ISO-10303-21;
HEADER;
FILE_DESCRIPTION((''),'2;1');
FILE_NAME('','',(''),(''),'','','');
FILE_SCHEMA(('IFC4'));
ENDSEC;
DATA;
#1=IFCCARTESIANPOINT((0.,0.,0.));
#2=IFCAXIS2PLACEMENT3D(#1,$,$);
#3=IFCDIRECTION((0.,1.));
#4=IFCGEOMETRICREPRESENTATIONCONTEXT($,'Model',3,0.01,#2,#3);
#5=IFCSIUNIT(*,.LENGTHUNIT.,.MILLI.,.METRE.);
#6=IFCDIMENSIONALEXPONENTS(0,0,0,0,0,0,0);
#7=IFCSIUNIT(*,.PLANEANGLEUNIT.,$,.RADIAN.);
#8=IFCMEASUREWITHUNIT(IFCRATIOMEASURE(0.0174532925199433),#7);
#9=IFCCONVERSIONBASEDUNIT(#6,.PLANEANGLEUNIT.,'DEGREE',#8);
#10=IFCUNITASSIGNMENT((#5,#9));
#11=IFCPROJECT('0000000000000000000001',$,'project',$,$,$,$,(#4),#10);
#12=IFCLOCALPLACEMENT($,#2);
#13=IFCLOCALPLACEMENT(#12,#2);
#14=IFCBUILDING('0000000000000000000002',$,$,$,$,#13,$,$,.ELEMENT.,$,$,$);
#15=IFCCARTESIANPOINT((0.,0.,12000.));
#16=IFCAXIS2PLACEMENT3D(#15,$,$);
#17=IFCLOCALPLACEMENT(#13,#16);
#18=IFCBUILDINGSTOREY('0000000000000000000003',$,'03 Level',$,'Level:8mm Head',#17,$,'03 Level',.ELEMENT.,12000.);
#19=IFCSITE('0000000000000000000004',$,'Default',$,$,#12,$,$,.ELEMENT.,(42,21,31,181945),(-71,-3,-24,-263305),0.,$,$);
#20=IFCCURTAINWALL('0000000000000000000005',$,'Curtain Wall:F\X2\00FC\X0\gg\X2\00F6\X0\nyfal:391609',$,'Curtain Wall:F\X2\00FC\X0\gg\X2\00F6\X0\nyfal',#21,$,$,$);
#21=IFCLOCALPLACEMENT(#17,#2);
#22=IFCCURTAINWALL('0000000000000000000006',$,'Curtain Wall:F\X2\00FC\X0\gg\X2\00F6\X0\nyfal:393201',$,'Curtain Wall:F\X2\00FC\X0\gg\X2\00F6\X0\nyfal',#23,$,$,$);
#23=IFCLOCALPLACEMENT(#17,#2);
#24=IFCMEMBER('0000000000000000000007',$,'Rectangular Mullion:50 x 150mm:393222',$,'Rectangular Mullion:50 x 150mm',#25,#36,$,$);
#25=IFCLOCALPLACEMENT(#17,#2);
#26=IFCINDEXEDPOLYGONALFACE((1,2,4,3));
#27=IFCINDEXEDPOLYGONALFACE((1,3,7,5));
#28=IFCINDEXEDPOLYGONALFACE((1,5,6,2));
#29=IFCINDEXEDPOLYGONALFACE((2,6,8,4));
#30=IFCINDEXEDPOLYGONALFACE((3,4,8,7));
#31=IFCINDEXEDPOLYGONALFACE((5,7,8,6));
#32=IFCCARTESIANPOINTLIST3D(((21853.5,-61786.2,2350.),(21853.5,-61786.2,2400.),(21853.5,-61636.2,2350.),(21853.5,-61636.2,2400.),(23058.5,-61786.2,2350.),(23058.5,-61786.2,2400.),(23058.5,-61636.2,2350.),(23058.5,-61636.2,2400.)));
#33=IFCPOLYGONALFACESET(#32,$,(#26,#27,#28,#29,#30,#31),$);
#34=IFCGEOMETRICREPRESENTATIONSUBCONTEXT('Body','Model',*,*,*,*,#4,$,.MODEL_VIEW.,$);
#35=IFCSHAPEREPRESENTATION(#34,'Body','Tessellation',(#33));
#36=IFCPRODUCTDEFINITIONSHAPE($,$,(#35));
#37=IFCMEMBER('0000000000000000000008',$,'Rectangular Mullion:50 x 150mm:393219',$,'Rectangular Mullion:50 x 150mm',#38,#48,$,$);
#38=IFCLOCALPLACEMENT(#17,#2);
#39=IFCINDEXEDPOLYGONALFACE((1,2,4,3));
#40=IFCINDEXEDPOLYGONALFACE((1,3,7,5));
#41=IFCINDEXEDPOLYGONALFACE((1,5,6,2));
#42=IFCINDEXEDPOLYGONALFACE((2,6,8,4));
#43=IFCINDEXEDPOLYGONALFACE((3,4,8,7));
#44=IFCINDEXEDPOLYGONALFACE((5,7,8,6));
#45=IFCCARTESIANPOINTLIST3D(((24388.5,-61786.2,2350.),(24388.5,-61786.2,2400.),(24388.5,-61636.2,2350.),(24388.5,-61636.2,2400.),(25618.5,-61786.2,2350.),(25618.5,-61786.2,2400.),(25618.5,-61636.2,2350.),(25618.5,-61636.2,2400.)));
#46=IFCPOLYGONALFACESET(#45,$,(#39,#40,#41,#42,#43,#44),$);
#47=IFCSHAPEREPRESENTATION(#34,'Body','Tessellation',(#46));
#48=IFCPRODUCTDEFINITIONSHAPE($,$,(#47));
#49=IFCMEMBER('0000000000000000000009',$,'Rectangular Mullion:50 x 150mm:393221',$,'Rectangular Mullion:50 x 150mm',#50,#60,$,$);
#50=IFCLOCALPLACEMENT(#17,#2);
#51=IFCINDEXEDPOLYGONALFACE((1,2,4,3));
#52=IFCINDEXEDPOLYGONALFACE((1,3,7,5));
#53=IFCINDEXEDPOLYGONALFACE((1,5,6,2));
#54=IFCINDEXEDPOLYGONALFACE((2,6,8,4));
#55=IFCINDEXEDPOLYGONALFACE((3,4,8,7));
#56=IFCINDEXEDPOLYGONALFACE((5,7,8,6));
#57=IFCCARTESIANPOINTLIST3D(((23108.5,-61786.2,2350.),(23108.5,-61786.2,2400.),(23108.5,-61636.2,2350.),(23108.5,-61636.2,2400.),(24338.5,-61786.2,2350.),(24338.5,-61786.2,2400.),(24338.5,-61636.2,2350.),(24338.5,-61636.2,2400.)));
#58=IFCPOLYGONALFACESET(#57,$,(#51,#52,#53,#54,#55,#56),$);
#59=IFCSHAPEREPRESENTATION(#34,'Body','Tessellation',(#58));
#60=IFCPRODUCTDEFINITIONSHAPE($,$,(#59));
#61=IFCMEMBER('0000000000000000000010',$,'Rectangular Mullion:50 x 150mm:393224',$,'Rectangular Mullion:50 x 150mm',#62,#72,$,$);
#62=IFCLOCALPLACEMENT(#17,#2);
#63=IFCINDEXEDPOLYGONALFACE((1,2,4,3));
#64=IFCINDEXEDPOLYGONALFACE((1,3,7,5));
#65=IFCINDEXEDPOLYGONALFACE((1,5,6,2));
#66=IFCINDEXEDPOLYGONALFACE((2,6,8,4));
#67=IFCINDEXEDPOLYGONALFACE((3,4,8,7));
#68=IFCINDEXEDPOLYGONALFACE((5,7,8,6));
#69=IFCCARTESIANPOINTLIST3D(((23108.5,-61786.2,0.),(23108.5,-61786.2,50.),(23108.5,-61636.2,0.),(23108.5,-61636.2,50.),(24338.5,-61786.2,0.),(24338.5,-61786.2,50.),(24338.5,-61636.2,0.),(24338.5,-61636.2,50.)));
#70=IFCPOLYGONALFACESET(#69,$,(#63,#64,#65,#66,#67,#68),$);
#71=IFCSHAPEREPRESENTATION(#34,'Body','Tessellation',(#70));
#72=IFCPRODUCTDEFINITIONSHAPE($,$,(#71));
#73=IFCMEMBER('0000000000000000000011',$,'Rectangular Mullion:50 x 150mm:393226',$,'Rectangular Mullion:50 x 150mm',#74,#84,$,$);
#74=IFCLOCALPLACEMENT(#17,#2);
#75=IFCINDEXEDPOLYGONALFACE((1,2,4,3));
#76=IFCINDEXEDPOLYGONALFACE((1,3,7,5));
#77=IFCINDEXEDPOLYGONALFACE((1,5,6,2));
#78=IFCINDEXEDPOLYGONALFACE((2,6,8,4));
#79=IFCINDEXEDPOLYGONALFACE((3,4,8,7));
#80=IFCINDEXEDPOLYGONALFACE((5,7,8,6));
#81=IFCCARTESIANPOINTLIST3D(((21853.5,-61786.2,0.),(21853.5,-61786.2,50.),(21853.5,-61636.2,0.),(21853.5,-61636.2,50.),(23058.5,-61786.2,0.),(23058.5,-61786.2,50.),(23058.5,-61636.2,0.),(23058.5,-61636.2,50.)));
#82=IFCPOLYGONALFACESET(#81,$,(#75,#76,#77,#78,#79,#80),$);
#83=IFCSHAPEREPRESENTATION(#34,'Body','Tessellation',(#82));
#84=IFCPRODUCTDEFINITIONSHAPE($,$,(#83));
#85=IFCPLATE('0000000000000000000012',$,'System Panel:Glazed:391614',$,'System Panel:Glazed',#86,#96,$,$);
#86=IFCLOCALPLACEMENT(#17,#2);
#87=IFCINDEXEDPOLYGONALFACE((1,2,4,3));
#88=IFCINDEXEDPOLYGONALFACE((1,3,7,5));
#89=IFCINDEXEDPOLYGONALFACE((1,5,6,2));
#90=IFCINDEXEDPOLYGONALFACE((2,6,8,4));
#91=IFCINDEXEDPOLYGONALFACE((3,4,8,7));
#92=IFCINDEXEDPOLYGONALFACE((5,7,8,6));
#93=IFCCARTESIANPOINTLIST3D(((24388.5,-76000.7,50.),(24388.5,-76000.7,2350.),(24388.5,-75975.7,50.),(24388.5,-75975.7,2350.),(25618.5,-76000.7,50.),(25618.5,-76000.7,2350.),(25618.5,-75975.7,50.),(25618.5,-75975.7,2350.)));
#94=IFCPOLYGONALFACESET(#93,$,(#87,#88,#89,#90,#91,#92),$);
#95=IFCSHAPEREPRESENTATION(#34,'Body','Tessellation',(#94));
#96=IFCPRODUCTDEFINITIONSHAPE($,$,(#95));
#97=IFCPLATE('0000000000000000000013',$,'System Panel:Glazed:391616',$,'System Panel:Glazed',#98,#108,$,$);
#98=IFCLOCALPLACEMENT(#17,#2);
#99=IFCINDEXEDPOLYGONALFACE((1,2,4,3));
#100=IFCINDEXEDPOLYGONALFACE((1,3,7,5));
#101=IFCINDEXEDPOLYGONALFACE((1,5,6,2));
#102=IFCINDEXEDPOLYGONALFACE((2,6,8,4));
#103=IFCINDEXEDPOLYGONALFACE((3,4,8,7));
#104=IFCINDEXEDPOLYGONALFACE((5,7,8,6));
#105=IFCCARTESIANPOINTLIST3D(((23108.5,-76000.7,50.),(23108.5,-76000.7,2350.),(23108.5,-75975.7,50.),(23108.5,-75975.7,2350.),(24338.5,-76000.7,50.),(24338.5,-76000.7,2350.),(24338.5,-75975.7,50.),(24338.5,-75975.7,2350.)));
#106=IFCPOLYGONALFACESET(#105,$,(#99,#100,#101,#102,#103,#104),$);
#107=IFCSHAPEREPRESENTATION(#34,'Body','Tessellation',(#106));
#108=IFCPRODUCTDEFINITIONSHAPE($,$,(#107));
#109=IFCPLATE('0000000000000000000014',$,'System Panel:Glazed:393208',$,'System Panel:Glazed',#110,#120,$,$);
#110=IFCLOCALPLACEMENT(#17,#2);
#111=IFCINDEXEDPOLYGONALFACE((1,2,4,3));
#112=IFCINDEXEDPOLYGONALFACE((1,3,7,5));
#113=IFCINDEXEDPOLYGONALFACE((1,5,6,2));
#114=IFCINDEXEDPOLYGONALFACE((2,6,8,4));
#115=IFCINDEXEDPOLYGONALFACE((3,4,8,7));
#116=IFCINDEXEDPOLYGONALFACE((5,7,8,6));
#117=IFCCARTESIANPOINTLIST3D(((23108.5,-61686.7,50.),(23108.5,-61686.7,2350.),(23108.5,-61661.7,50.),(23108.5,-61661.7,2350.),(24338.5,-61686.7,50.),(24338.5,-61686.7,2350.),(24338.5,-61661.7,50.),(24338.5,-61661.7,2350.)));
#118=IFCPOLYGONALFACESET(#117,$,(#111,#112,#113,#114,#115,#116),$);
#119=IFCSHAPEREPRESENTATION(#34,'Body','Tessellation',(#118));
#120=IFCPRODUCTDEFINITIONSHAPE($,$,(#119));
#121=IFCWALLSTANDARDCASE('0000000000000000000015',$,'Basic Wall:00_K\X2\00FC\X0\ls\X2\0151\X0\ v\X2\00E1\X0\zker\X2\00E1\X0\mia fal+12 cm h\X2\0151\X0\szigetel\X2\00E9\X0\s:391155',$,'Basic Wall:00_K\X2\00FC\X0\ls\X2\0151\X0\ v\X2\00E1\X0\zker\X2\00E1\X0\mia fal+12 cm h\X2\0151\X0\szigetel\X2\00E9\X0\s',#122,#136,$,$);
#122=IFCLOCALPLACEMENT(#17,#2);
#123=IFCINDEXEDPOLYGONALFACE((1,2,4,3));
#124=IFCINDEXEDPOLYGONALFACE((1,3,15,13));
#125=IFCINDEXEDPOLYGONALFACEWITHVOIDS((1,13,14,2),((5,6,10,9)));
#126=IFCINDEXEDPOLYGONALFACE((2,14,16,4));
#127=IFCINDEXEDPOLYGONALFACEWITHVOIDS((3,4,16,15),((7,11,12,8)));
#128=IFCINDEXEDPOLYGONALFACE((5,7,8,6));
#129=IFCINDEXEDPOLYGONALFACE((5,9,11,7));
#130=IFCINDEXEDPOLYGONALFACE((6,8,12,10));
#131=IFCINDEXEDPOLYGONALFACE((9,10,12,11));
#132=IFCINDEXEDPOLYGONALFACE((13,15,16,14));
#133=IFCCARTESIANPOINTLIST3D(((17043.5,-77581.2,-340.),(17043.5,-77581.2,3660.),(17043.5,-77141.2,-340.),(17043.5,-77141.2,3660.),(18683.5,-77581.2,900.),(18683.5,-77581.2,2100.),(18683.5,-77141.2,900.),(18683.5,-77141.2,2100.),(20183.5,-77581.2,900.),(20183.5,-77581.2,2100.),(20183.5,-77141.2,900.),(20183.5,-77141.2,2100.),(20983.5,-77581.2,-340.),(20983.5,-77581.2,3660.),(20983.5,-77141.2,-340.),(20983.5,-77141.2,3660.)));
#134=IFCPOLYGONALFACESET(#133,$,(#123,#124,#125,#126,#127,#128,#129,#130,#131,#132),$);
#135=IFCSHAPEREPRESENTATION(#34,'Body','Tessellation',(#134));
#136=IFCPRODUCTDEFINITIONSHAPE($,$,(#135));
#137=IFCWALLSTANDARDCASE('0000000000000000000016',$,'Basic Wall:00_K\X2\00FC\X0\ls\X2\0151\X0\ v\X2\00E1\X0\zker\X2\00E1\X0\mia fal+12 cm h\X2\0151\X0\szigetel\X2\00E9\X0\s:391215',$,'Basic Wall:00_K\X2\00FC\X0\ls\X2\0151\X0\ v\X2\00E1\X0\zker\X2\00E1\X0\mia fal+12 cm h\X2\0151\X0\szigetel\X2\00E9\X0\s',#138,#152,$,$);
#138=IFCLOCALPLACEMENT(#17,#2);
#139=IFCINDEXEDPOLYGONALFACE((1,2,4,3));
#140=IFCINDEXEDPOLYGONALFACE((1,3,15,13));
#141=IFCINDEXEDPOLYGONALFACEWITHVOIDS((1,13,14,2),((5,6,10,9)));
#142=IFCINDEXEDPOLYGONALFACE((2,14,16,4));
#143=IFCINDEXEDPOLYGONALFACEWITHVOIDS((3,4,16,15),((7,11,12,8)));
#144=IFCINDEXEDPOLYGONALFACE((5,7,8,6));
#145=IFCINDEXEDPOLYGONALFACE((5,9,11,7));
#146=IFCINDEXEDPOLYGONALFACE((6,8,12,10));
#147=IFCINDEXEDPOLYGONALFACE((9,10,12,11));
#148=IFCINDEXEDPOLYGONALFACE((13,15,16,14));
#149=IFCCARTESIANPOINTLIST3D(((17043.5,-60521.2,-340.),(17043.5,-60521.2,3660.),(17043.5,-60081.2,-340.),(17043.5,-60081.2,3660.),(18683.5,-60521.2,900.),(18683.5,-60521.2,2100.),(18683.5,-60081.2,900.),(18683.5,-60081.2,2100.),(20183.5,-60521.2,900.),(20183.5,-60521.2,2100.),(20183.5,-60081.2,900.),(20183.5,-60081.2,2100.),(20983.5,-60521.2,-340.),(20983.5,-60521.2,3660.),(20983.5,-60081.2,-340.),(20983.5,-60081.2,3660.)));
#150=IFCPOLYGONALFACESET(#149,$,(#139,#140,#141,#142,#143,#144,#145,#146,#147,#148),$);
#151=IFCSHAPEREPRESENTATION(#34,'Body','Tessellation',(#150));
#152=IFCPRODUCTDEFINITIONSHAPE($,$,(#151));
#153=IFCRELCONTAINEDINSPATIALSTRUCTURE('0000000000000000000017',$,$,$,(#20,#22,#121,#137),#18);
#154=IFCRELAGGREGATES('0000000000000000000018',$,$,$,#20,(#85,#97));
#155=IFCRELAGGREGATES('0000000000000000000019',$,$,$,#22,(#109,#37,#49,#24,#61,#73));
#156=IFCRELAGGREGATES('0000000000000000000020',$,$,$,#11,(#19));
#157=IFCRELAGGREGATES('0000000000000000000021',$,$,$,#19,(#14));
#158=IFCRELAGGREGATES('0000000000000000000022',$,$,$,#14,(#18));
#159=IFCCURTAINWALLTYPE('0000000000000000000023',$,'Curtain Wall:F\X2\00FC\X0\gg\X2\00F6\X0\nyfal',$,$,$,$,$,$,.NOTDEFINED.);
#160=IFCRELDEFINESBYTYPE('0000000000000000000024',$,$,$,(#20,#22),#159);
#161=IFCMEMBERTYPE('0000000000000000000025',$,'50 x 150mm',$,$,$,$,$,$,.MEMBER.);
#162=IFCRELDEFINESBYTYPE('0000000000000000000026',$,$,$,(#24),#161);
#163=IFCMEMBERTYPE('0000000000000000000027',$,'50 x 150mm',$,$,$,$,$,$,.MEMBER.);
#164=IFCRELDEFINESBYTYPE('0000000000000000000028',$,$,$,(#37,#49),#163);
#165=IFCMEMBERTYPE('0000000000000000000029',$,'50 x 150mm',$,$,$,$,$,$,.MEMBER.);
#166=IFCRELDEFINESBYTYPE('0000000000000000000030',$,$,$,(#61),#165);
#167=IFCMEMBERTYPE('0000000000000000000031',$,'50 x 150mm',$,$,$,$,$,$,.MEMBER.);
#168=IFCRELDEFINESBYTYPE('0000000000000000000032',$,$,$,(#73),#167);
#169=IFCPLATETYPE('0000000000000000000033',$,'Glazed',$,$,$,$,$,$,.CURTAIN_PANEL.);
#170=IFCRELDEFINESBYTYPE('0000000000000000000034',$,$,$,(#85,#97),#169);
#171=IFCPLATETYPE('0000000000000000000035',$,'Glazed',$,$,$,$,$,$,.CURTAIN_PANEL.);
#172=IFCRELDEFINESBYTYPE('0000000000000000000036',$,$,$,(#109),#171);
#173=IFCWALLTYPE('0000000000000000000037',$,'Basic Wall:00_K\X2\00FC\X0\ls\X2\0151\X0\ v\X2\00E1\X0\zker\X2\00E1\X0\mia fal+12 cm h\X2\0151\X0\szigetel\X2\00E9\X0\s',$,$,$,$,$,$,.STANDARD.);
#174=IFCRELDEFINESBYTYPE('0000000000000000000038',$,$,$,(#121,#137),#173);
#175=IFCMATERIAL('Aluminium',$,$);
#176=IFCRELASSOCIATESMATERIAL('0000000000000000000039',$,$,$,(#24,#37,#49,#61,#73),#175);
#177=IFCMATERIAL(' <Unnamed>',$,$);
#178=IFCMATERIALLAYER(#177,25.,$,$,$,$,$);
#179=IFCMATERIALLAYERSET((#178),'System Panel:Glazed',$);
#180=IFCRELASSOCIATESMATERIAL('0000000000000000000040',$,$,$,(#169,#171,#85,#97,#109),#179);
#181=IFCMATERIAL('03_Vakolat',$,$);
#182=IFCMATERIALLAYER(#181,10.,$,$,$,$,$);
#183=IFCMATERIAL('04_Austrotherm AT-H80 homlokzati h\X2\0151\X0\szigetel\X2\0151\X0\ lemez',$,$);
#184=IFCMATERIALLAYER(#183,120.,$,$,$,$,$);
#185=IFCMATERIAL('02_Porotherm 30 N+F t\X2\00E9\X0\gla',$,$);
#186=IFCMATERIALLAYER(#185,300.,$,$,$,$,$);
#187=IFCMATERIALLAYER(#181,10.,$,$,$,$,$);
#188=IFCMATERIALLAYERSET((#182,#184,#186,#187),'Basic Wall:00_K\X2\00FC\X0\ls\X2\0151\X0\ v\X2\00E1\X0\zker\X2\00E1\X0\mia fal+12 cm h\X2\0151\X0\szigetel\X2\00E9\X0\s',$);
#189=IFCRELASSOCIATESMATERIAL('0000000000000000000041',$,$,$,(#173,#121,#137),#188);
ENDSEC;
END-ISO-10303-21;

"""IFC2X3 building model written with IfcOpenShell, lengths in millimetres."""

from ifc_helpers import new_model, entity, si_unit, converted_unit, direction, frame, frame_2d, origin, origin_2d_with_axis, place, context, subcontext, project, spatial, rectangle, extrude, source, transform, mapped, material, layer, layer_set, layer_usage, type_object, type_shapes, element, aggregate, save


model = new_model("IFC2X3")

# Units and contexts
model_context = context("Model", 3, precision=0.01, world=origin(), true_north=direction((0.0, 1.0)))
body_context = subcontext(model_context, "Body", "Model", "MODEL_VIEW")
ifc_project = project(units=[si_unit("LENGTHUNIT", "METRE", prefix="MILLI"), converted_unit("PLANEANGLEUNIT", "DEGREE", entity("IfcRatioMeasure", 0.0174532925199433), si_unit("PLANEANGLEUNIT", "RADIAN"), dimensions=[0, 0, 0, 0, 0, 0, 0])], contexts=[model_context])

# Site, building, storey
site_placement = place(None, origin())
site = spatial("IfcSite", under=ifc_project, at=site_placement, Name="Default", CompositionType="ELEMENT", RefLatitude=(42, 21, 31, 181945), RefLongitude=(-71, -3, -24, -263305), RefElevation=0.0)
building_placement = place(site_placement, origin())
building = spatial("IfcBuilding", under=site, at=building_placement, CompositionType="ELEMENT")
storey_placement = place(building_placement, frame((0.0, 0.0, 12000.0)))
storey = spatial("IfcBuildingStorey", under=building, at=storey_placement, Name="03 Level", ObjectType="Level:8mm Head", LongName="03 Level", CompositionType="ELEMENT", Elevation=12000.0)

# Curtain walls, members
curtain_wall_type = type_object("IfcCurtainWallType", Name="Curtain Wall:Függönyfal", PredefinedType="NOTDEFINED")
curtain_wall_1_placement = place(storey_placement, frame((0.0, 0.0, -12000.0)))
curtain_wall_1 = element("IfcCurtainWall", 1, at=curtain_wall_1_placement, inside=storey, type_object=curtain_wall_type, Name="Curtain Wall:Függönyfal:391609", ObjectType="Curtain Wall:Függönyfal")
ifc_material_1 = material(Name="Aluminium")
curtain_wall_2_placement = place(storey_placement, frame((0.0, 0.0, -12000.0)))
curtain_wall_2 = element("IfcCurtainWall", 2, at=curtain_wall_2_placement, inside=storey, type_object=curtain_wall_type, Name="Curtain Wall:Függönyfal:393201", ObjectType="Curtain Wall:Függönyfal")
member_type_1 = type_object("IfcMemberType", Name="50 x 150mm", PredefinedType="MEMBER")
shared_shape_1 = source(origin(), body_context, "Body", "SweptSolid", [
    extrude(rectangle(XDim=150.0, YDim=50.0, at=origin_2d_with_axis()), frame((-25.0, 0.0, -1205.0), z_axis=(0.0, 0.0, 1.0), x_axis=(0.0, -1.0, 0.0)), (0.0, 0.0, 1.0), 1205.0),
])
type_shapes(member_type_1, [shared_shape_1])
member_1_placement = place(storey_placement, frame((21853.5, -61711.2, 2400.0), z_axis=(-1.0, 0.0, 0.0), x_axis=(0.0, 0.0, 1.0)))
member_1 = element("IfcMember", 3, at=member_1_placement, type_object=member_type_1, material=ifc_material_1, Name="Rectangular Mullion:50 x 150mm:393222", ObjectType="Rectangular Mullion:50 x 150mm", context=body_context, shape_type="MappedRepresentation", body=[
    mapped(shared_shape_1, transform((0.0, 0.0, 0.0), scale=1.0)),
])
member_type_2 = type_object("IfcMemberType", Name="50 x 150mm", PredefinedType="MEMBER")
shared_shape_2 = source(origin(), body_context, "Body", "SweptSolid", [
    extrude(rectangle(XDim=150.0, YDim=50.0, at=origin_2d_with_axis()), frame((-25.0, 0.0, -1230.0), z_axis=(0.0, 0.0, 1.0), x_axis=(0.0, -1.0, 0.0)), (0.0, 0.0, 1.0), 1230.0),
])
type_shapes(member_type_2, [shared_shape_2])
member_2_placement = place(storey_placement, frame((24388.5, -61711.2, 2400.0), z_axis=(-1.0, 0.0, 0.0), x_axis=(0.0, 0.0, 1.0)))
member_2 = element("IfcMember", 4, at=member_2_placement, type_object=member_type_2, material=ifc_material_1, Name="Rectangular Mullion:50 x 150mm:393219", ObjectType="Rectangular Mullion:50 x 150mm", context=body_context, shape_type="MappedRepresentation", body=[
    mapped(shared_shape_2, transform((0.0, 0.0, 0.0), scale=1.0)),
])
member_3_placement = place(storey_placement, frame((23108.5, -61711.2, 2400.0), z_axis=(-1.0, 0.0, 0.0), x_axis=(0.0, 0.0, 1.0)))
member_3 = element("IfcMember", 5, at=member_3_placement, type_object=member_type_2, material=ifc_material_1, Name="Rectangular Mullion:50 x 150mm:393221", ObjectType="Rectangular Mullion:50 x 150mm", context=body_context, shape_type="MappedRepresentation", body=[
    mapped(shared_shape_2, transform((0.0, 0.0, 0.0), scale=1.0)),
])
member_type_3 = type_object("IfcMemberType", Name="50 x 150mm", PredefinedType="MEMBER")
shared_shape_3 = source(origin(), body_context, "Body", "SweptSolid", [
    extrude(rectangle(XDim=150.0, YDim=50.0, at=origin_2d_with_axis()), frame((-25.0, 0.0, -1230.0), z_axis=(0.0, 0.0, 1.0), x_axis=(0.0, -1.0, 0.0)), (0.0, 0.0, 1.0), 1230.0),
])
type_shapes(member_type_3, [shared_shape_3])
member_4_placement = place(storey_placement, frame((24338.5, -61711.2, 0.0), z_axis=(1.0, 0.0, 0.0), x_axis=(0.0, 0.0, -1.0)))
member_4 = element("IfcMember", 6, at=member_4_placement, type_object=member_type_3, material=ifc_material_1, Name="Rectangular Mullion:50 x 150mm:393224", ObjectType="Rectangular Mullion:50 x 150mm", context=body_context, shape_type="MappedRepresentation", body=[
    mapped(shared_shape_3, transform((0.0, 0.0, 0.0), scale=1.0)),
])
member_type_4 = type_object("IfcMemberType", Name="50 x 150mm", PredefinedType="MEMBER")
shared_shape_4 = source(origin(), body_context, "Body", "SweptSolid", [
    extrude(rectangle(XDim=150.0, YDim=50.0, at=origin_2d_with_axis()), frame((-25.0, 0.0, -1205.0), z_axis=(0.0, 0.0, 1.0), x_axis=(0.0, -1.0, 0.0)), (0.0, 0.0, 1.0), 1205.0),
])
type_shapes(member_type_4, [shared_shape_4])
member_5_placement = place(storey_placement, frame((23058.5, -61711.2, 0.0), z_axis=(1.0, 0.0, 0.0), x_axis=(0.0, 0.0, -1.0)))
member_5 = element("IfcMember", 7, at=member_5_placement, type_object=member_type_4, material=ifc_material_1, Name="Rectangular Mullion:50 x 150mm:393226", ObjectType="Rectangular Mullion:50 x 150mm", context=body_context, shape_type="MappedRepresentation", body=[
    mapped(shared_shape_4, transform((0.0, 0.0, 0.0), scale=1.0)),
])

# Plates
ifc_material_2 = material(Name=" <Unnamed>")
ifc_layer_1 = layer(ifc_material_2, 25.0)
ifc_layer_set_1 = layer_set([ifc_layer_1], Name="System Panel:Glazed")
ifc_layer_usage_1 = layer_usage(ifc_layer_set_1, "AXIS3", "POSITIVE", 0.1)
plate_type_1 = type_object("IfcPlateType", Name="Glazed", PredefinedType="CURTAIN_PANEL", material=ifc_layer_set_1)
shared_shape_5 = source(origin(), body_context, "Body", "SweptSolid", [
    extrude(rectangle(XDim=25.0, YDim=1230.0, at=origin_2d_with_axis()), frame((615.0, 12.5, 0.0), z_axis=(0.0, 0.0, 1.0), x_axis=(0.0, 1.0, 0.0)), (0.0, 0.0, 1.0), 2300.0),
])
type_shapes(plate_type_1, [shared_shape_5])
plate_1_placement = place(curtain_wall_1_placement, frame((25618.5, -75975.7, 12050.0), z_axis=(0.0, 0.0, 1.0), x_axis=(-1.0, 0.0, 0.0)))
plate_1 = element("IfcPlate", 8, at=plate_1_placement, type_object=plate_type_1, material=ifc_layer_usage_1, Name="System Panel:Glazed:391614", ObjectType="System Panel:Glazed", context=body_context, shape_type="MappedRepresentation", body=[
    mapped(shared_shape_5, transform((0.0, 0.0, 0.0), scale=1.0)),
])
ifc_layer_usage_2 = layer_usage(ifc_layer_set_1, "AXIS3", "POSITIVE", 0.1)
plate_2_placement = place(curtain_wall_1_placement, frame((24338.5, -75975.7, 12050.0), z_axis=(0.0, 0.0, 1.0), x_axis=(-1.0, 0.0, 0.0)))
plate_2 = element("IfcPlate", 9, at=plate_2_placement, type_object=plate_type_1, material=ifc_layer_usage_2, Name="System Panel:Glazed:391616", ObjectType="System Panel:Glazed", context=body_context, shape_type="MappedRepresentation", body=[
    mapped(shared_shape_5, transform((0.0, 0.0, 0.0), scale=1.0)),
])
ifc_layer_usage_3 = layer_usage(ifc_layer_set_1, "AXIS3", "POSITIVE", 0.1)
plate_type_2 = type_object("IfcPlateType", Name="Glazed", PredefinedType="CURTAIN_PANEL", material=ifc_layer_set_1)
shared_shape_6 = source(origin(), body_context, "Body", "SweptSolid", [
    extrude(rectangle(XDim=25.0, YDim=1230.0, at=frame_2d((0.0, 0.0), x_axis=(1.0, 0.0))), frame((615.0, 12.5, 0.0), z_axis=(0.0, 0.0, 1.0), x_axis=(0.0, 1.0, 0.0)), (0.0, 0.0, 1.0), 2300.0),
])
type_shapes(plate_type_2, [shared_shape_6])
plate_3_placement = place(curtain_wall_2_placement, frame((24338.5, -61661.7, 12050.0), z_axis=(0.0, 0.0, 1.0), x_axis=(-1.0, 0.0, 0.0)))
plate_3 = element("IfcPlate", 10, at=plate_3_placement, type_object=plate_type_2, material=ifc_layer_usage_3, Name="System Panel:Glazed:393208", ObjectType="System Panel:Glazed", context=body_context, shape_type="MappedRepresentation", body=[
    mapped(shared_shape_6, transform((0.0, 0.0, 0.0), scale=1.0)),
])

# Walls, openings
ifc_material_3 = material(Name="03_Vakolat")
ifc_layer_2 = layer(ifc_material_3, 10.0)
ifc_material_4 = material(Name="04_Austrotherm AT-H80 homlokzati hőszigetelő lemez")
ifc_layer_3 = layer(ifc_material_4, 120.0)
ifc_material_5 = material(Name="02_Porotherm 30 N+F tégla")
ifc_layer_4 = layer(ifc_material_5, 300.0)
ifc_layer_5 = layer(ifc_material_3, 10.0)
ifc_layer_set_2 = layer_set([ifc_layer_2, ifc_layer_3, ifc_layer_4, ifc_layer_5], Name="Basic Wall:00_Külső vázkerámia fal+12 cm hőszigetelés")
ifc_layer_usage_4 = layer_usage(ifc_layer_set_2, "AXIS2", "NEGATIVE", 220.0)
wall_type_1 = type_object("IfcWallType", Name="Basic Wall:00_Külső vázkerámia fal+12 cm hőszigetelés", PredefinedType="STANDARD", material=ifc_layer_set_2)
wall_1_placement = place(storey_placement, frame((20983.5, -77361.2, -340.0), z_axis=(0.0, 0.0, 1.0), x_axis=(-1.0, 0.0, 0.0)))
wall_1 = element("IfcWallStandardCase", 11, at=wall_1_placement, inside=storey, type_object=wall_type_1, material=ifc_layer_usage_4, Name="Basic Wall:00_Külső vázkerámia fal+12 cm hőszigetelés:391155", ObjectType="Basic Wall:00_Külső vázkerámia fal+12 cm hőszigetelés", context=body_context, shape_type="SweptSolid", body=[
    extrude(rectangle(XDim=3940.0, YDim=440.0, at=frame_2d((1970.0, 0.0), x_axis=(-1.0, 0.0))), origin(), (0.0, 0.0, 1.0), 4000.0),
])
opening_1_placement = place(wall_1_placement, frame((2300.0, 1744.0, 1240.0), z_axis=(0.0, 0.0, 1.0), x_axis=(-1.0, 0.0, 0.0)))
element("IfcOpeningElement", 12, at=opening_1_placement, cuts=wall_1, ObjectType="Opening", context=body_context, shape_type="SweptSolid", body=[
    extrude(rectangle(XDim=1200.0, YDim=1500.0, at=frame_2d((0.0, 0.0), x_axis=(0.0, 1.0))), frame((750.0, 3048.0, 600.0), z_axis=(0.0, -1.0, 0.0), x_axis=(1.0, 0.0, 0.0)), (0.0, 0.0, 1.0), 3048.0),
])
ifc_layer_usage_5 = layer_usage(ifc_layer_set_2, "AXIS2", "POSITIVE", -220.0)
wall_2_placement = place(storey_placement, frame((20983.5, -60301.2, -340.0), z_axis=(0.0, 0.0, 1.0), x_axis=(-1.0, 0.0, 0.0)))
wall_2 = element("IfcWallStandardCase", 13, at=wall_2_placement, inside=storey, type_object=wall_type_1, material=ifc_layer_usage_5, Name="Basic Wall:00_Külső vázkerámia fal+12 cm hőszigetelés:391215", ObjectType="Basic Wall:00_Külső vázkerámia fal+12 cm hőszigetelés", context=body_context, shape_type="SweptSolid", body=[
    extrude(rectangle(XDim=3940.0, YDim=440.0, at=frame_2d((1970.0, 0.0), x_axis=(-1.0, 0.0))), origin(), (0.0, 0.0, 1.0), 4000.0),
])
opening_2_placement = place(wall_2_placement, frame((2300.0, 1304.0, 1240.0), z_axis=(0.0, 0.0, 1.0), x_axis=(-1.0, 0.0, 0.0)))
element("IfcOpeningElement", 14, at=opening_2_placement, cuts=wall_2, ObjectType="Opening", context=body_context, shape_type="SweptSolid", body=[
    extrude(rectangle(XDim=1200.0, YDim=1500.0, at=frame_2d((0.0, 0.0), x_axis=(0.0, 1.0))), frame((750.0, 3048.0, 600.0), z_axis=(0.0, -1.0, 0.0), x_axis=(1.0, 0.0, 0.0)), (0.0, 0.0, 1.0), 3048.0),
])

aggregate(curtain_wall_1, [plate_1, plate_2])
aggregate(curtain_wall_2, [plate_3, member_2, member_3, member_1, member_4, member_5])

save(model, "model.ifc")
